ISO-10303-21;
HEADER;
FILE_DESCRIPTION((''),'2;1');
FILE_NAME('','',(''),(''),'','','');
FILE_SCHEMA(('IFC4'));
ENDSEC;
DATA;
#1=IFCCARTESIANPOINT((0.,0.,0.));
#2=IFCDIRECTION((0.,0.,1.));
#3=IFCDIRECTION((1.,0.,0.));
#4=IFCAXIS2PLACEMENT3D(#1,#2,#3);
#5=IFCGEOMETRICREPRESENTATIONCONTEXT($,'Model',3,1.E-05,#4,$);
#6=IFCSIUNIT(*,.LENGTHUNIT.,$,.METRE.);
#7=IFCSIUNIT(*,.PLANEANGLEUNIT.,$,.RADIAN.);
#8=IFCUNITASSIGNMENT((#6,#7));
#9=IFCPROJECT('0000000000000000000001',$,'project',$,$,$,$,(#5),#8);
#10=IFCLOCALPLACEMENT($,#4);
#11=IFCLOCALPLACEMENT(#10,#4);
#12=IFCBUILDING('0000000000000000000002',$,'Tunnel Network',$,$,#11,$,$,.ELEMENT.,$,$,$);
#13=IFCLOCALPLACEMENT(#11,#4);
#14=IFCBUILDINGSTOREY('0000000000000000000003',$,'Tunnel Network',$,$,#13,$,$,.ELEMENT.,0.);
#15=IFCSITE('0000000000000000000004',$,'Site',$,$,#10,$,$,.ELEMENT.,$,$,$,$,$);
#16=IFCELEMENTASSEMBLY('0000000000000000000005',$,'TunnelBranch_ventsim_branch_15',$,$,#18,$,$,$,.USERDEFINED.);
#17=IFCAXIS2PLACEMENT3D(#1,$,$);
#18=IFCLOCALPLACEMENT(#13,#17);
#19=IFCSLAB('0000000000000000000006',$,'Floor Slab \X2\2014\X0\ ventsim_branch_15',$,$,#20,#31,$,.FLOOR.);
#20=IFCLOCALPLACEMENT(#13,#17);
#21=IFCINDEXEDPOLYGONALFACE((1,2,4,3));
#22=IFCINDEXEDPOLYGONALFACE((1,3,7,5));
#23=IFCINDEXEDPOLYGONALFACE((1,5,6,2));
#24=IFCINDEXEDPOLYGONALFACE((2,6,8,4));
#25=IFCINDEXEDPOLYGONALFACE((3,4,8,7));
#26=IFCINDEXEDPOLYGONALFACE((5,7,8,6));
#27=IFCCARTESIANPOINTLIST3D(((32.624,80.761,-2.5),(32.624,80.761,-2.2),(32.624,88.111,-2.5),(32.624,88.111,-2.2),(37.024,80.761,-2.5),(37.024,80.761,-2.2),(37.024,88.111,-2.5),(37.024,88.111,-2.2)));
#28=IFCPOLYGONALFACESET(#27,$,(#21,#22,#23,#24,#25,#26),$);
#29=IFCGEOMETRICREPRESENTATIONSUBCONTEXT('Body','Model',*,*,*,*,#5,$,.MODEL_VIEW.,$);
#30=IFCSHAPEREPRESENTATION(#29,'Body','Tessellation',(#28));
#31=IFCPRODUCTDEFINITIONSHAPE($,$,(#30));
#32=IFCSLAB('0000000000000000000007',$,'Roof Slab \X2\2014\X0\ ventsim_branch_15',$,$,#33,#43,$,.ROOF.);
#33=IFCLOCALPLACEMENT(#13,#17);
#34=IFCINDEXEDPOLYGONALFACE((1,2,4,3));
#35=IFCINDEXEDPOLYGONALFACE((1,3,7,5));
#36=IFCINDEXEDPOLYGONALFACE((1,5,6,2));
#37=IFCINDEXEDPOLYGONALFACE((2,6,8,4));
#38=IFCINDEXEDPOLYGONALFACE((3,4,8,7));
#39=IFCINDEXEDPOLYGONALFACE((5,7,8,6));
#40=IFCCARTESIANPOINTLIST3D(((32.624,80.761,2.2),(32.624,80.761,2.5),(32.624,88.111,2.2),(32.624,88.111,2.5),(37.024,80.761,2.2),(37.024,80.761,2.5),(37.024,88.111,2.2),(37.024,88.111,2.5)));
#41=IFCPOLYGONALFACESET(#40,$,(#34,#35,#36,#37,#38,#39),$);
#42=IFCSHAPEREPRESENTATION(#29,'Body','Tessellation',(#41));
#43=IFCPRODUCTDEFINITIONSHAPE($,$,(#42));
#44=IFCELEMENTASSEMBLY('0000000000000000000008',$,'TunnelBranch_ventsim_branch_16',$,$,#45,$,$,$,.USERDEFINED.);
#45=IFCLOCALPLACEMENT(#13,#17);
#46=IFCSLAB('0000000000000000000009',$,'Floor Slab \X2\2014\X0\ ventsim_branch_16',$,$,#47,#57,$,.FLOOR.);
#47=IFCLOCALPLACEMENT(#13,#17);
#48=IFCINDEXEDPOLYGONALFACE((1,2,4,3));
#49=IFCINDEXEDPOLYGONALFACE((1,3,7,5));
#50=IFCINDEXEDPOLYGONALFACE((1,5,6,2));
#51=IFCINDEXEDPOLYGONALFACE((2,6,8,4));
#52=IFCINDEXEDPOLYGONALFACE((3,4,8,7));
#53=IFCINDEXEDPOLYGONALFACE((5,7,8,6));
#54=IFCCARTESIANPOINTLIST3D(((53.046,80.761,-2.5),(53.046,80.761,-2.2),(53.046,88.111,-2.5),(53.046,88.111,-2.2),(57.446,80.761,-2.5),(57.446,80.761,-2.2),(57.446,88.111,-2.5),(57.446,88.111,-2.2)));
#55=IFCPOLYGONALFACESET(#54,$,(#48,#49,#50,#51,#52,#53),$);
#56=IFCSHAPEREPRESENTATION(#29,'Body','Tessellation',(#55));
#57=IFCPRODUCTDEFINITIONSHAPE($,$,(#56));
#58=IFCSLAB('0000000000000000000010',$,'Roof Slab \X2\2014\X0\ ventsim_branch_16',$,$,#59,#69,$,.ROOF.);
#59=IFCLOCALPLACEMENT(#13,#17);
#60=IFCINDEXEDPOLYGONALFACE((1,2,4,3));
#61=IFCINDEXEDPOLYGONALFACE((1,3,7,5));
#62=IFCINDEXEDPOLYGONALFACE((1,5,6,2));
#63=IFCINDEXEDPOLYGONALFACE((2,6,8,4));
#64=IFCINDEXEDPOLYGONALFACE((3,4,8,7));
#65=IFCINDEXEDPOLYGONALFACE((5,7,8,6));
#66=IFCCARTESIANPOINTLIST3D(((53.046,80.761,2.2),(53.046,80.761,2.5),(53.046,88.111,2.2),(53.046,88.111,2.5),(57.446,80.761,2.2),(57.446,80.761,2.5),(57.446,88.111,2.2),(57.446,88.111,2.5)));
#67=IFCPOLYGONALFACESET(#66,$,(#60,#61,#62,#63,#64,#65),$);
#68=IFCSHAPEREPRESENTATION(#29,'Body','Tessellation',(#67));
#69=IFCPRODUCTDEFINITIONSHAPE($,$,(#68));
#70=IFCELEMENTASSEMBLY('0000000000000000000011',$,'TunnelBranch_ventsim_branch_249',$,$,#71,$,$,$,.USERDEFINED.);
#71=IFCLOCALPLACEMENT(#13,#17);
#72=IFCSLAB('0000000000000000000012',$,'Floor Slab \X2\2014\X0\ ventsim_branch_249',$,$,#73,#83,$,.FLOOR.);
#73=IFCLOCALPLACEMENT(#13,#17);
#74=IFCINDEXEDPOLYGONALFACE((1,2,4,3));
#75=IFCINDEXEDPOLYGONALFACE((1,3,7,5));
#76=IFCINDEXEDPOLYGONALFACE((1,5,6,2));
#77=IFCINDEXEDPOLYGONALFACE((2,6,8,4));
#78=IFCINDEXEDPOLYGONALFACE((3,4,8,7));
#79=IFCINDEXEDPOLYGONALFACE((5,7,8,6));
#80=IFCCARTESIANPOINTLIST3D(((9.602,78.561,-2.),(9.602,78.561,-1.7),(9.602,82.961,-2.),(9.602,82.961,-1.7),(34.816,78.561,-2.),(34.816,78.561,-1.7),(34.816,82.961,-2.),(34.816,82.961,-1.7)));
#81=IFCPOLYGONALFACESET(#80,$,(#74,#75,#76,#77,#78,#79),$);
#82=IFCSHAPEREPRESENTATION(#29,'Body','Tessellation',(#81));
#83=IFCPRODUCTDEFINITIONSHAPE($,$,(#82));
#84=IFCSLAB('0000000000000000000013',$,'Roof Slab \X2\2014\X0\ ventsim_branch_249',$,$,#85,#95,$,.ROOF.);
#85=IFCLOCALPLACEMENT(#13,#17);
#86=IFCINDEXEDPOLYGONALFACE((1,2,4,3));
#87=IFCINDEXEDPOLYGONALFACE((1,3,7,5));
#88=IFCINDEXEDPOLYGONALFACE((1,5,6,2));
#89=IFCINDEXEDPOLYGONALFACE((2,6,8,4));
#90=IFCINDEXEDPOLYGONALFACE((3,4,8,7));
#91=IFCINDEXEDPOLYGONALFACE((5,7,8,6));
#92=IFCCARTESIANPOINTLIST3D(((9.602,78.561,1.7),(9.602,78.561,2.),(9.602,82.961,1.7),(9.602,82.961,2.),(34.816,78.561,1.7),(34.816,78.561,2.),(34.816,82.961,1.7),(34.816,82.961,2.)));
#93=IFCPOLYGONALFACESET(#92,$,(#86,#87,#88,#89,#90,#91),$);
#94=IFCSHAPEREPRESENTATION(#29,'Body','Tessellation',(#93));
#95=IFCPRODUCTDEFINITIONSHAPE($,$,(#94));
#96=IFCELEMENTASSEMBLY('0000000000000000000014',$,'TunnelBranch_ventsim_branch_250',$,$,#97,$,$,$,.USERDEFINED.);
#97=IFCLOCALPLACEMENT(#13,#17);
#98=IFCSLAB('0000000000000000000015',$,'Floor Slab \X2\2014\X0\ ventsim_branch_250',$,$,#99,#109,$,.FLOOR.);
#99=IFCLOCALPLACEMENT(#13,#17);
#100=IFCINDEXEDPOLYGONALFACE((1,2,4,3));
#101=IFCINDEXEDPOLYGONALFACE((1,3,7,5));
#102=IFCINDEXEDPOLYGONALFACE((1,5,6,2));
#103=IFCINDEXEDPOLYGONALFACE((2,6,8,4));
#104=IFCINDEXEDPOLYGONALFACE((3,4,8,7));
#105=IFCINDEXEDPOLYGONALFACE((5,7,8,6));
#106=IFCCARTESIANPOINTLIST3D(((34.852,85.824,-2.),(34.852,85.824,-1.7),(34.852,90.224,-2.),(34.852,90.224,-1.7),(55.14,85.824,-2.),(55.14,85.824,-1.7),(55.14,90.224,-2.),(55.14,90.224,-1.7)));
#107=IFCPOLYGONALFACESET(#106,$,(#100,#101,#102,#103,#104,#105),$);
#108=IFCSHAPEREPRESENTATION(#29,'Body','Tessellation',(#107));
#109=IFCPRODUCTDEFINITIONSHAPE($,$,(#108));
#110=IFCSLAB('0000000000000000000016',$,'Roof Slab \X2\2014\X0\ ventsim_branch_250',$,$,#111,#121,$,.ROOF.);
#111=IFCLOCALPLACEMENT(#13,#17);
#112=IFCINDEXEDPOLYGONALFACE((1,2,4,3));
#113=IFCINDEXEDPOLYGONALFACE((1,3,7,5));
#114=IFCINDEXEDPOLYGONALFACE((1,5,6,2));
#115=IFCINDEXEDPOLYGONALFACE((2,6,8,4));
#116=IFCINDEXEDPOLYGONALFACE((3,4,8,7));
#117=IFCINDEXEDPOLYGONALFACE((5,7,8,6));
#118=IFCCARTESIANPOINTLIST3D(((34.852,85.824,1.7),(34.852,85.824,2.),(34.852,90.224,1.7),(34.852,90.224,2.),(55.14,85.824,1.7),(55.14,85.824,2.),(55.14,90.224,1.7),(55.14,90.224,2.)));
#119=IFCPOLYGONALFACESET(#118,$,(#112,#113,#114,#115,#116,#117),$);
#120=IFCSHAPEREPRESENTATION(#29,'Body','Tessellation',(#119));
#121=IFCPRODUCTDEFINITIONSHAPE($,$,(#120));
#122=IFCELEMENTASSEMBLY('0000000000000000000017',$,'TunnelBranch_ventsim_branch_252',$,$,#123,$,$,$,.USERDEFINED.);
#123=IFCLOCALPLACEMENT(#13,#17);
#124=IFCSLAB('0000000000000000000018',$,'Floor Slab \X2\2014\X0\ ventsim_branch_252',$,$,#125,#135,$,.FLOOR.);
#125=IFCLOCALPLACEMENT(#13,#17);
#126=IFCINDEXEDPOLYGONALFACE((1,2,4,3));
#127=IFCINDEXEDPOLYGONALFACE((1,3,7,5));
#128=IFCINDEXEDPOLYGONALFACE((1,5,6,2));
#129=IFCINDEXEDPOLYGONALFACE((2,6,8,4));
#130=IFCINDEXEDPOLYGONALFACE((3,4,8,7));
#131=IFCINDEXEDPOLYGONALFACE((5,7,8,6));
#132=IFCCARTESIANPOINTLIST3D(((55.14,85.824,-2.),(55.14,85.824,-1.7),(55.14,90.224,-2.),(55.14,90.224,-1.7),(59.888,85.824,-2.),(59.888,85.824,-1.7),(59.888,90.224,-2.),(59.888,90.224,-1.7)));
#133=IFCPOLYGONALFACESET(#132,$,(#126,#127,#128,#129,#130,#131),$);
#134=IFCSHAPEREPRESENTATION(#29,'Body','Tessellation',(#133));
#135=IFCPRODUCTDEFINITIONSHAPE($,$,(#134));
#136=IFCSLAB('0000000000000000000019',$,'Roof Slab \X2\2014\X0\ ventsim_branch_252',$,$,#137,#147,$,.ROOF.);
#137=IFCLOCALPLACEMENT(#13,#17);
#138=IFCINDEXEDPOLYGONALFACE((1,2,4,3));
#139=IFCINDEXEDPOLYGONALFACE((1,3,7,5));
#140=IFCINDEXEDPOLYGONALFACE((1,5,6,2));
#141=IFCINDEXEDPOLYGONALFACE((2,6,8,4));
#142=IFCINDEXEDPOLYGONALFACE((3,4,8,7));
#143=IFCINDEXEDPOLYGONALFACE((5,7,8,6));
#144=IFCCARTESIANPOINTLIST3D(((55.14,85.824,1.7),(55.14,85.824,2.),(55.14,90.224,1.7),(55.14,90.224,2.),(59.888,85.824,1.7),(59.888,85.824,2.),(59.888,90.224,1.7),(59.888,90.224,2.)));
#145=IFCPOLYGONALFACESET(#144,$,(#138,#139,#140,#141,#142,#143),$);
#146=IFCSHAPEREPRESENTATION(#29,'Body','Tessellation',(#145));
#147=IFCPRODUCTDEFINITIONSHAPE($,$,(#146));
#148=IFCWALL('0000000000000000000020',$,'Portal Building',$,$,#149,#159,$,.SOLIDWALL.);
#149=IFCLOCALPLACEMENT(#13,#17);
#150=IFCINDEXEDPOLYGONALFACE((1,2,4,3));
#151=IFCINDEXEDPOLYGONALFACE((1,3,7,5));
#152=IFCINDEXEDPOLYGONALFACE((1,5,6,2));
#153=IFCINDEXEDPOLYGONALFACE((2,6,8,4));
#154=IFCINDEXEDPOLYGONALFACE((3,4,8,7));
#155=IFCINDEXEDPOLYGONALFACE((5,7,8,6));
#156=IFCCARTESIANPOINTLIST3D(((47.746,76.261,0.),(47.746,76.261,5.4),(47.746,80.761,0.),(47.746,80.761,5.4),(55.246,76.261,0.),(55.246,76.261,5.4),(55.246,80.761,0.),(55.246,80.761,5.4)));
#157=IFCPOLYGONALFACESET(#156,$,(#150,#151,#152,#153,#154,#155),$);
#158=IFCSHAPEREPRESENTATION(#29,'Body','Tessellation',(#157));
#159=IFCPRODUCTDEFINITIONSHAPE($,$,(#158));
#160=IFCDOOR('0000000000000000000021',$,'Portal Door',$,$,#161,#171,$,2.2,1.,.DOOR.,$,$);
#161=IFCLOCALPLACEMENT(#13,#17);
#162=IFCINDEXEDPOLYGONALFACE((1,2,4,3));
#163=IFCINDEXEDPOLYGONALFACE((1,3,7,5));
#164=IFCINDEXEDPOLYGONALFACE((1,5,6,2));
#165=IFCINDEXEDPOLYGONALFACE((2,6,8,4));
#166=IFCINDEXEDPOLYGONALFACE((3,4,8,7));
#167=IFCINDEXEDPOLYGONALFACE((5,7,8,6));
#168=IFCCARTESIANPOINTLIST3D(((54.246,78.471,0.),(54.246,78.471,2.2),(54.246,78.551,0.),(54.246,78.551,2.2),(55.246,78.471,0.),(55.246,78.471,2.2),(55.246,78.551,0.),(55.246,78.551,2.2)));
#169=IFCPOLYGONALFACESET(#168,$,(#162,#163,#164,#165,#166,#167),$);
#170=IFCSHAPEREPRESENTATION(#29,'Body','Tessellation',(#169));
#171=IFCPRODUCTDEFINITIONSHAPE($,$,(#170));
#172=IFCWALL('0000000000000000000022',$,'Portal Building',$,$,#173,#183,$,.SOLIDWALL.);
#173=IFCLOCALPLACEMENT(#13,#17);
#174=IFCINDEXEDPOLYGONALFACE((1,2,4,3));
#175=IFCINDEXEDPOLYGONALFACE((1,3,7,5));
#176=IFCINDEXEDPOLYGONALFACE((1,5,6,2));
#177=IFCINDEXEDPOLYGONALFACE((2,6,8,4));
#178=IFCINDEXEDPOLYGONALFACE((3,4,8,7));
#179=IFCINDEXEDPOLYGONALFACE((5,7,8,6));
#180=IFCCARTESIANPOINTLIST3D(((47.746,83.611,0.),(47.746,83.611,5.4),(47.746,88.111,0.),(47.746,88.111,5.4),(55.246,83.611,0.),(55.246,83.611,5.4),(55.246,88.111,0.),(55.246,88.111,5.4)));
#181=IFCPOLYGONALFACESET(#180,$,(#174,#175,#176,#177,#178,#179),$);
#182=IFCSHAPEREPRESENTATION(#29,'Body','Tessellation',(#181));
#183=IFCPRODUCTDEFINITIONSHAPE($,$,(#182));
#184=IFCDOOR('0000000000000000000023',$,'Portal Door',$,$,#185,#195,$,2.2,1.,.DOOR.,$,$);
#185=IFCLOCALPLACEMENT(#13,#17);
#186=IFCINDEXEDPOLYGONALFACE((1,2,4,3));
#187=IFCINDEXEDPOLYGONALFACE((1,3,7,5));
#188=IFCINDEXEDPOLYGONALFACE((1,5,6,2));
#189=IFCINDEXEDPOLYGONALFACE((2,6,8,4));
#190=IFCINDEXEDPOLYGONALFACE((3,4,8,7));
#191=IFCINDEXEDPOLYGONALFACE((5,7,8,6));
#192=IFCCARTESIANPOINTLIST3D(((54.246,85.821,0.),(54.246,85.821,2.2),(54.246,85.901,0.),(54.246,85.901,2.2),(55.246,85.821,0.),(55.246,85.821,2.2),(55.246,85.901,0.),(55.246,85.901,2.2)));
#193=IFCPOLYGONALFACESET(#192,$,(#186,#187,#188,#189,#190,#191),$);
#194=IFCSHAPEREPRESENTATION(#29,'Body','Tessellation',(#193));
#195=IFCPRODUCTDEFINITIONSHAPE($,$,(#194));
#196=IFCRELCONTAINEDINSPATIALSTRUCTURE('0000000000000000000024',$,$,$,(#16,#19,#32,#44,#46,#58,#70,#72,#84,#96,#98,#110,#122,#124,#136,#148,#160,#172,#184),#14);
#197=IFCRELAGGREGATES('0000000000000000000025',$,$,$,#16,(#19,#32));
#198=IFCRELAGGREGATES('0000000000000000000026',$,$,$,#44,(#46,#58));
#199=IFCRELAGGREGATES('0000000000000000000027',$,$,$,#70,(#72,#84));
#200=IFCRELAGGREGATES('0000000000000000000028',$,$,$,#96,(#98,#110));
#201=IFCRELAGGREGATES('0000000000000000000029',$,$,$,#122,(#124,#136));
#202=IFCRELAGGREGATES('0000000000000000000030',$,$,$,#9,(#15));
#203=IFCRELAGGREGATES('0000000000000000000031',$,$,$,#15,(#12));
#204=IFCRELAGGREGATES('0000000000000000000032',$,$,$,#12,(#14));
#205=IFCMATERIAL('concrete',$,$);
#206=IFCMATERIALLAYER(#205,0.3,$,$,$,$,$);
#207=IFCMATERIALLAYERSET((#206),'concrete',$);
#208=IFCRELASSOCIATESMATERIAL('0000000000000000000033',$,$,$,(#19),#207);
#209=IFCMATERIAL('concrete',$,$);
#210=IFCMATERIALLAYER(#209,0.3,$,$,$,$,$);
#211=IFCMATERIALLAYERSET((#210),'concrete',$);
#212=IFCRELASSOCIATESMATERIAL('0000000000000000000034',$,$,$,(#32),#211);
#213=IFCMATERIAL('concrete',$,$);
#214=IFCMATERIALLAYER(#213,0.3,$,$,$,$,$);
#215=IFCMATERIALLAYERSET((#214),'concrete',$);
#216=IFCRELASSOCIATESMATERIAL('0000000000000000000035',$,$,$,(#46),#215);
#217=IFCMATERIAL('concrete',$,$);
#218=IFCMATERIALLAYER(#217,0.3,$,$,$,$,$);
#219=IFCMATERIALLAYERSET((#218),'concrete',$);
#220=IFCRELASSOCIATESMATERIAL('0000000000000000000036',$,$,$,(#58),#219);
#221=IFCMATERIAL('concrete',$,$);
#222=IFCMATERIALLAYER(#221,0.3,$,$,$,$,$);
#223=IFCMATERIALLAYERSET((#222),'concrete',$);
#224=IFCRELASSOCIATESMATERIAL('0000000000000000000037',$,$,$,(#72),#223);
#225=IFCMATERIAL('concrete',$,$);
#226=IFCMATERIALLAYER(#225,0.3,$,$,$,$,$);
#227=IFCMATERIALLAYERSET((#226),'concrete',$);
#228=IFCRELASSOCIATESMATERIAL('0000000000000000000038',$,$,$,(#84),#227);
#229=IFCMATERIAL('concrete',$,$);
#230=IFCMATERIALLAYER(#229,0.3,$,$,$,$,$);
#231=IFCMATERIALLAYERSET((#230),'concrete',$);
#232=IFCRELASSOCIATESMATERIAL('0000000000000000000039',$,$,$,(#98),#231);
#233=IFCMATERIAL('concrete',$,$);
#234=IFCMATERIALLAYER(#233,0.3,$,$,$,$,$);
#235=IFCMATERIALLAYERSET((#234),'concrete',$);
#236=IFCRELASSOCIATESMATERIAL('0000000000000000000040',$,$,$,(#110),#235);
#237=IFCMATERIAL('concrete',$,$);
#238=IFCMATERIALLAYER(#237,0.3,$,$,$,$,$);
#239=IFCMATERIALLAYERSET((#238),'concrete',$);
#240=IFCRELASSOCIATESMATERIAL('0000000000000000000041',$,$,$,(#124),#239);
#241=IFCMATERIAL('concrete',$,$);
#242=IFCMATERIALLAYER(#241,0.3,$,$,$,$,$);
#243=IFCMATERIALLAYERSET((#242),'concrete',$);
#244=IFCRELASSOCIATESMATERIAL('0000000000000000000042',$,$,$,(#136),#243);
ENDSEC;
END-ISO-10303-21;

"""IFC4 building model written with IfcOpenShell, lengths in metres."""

from ifc_helpers import new_model, si_unit, frame, origin_with_axes, origin_2d_with_axis, place, context, subcontext, project, spatial, rectangle, extrude, material, layer, layer_set, layer_usage, element, aggregate, save


model = new_model("IFC4")

# Units and contexts
model_context = context("Model", 3, precision=1e-05, world=origin_with_axes())
body_context = subcontext(model_context, "Body", "Model", "MODEL_VIEW")
ifc_project = project(units=[si_unit("LENGTHUNIT", "METRE"), si_unit("PLANEANGLEUNIT", "RADIAN")], contexts=[model_context])

# Site, building, storey
site_placement = place(None, origin_with_axes())
site = spatial("IfcSite", under=ifc_project, at=site_placement, Name="Site", CompositionType="ELEMENT")
building_placement = place(site_placement, origin_with_axes())
building = spatial("IfcBuilding", under=site, at=building_placement, Name="Tunnel Network", CompositionType="ELEMENT")
storey_placement = place(building_placement, origin_with_axes())
storey = spatial("IfcBuildingStorey", under=building, at=storey_placement, Name="Tunnel Network", CompositionType="ELEMENT", Elevation=0.0)

# Element assemblies, slabs
assembly_1_placement = place(storey_placement, frame((32.474, 80.761, 0.0), z_axis=(0.0, 1.0, 0.0), x_axis=(1.0, 0.0, 0.0)))
assembly_1 = element("IfcElementAssembly", 1, at=assembly_1_placement, inside=storey, Name="TunnelBranch_ventsim_branch_15", PredefinedType="USERDEFINED")
ifc_material_1 = material(Name="concrete")
ifc_layer_1 = layer(ifc_material_1, 0.3)
ifc_layer_set_1 = layer_set([ifc_layer_1], Name="concrete")
ifc_layer_usage_1 = layer_usage(ifc_layer_set_1, "AXIS3", "POSITIVE", 0.0)
slab_1_placement = place(storey_placement, frame((34.824, 80.761, -2.35), z_axis=(0.0, 1.0, 0.0), x_axis=(1.0, 0.0, 0.0)))
slab_1 = element("IfcSlab", 2, at=slab_1_placement, inside=storey, material=ifc_layer_usage_1, Name="Floor Slab — ventsim_branch_15", PredefinedType="FLOOR", context=body_context, shape_type="SweptSolid", body=[
    extrude(rectangle(XDim=4.4, YDim=0.3, at=origin_2d_with_axis()), origin_with_axes(), (0.0, 0.0, 1.0), 7.35),
])
ifc_material_2 = material(Name="concrete")
ifc_layer_2 = layer(ifc_material_2, 0.3)
ifc_layer_set_2 = layer_set([ifc_layer_2], Name="concrete")
ifc_layer_usage_2 = layer_usage(ifc_layer_set_2, "AXIS3", "POSITIVE", 0.0)
slab_2_placement = place(storey_placement, frame((34.824, 80.761, 2.35), z_axis=(0.0, 1.0, 0.0), x_axis=(1.0, 0.0, 0.0)))
slab_2 = element("IfcSlab", 3, at=slab_2_placement, inside=storey, material=ifc_layer_usage_2, Name="Roof Slab — ventsim_branch_15", PredefinedType="ROOF", context=body_context, shape_type="SweptSolid", body=[
    extrude(rectangle(XDim=4.4, YDim=0.3, at=origin_2d_with_axis()), origin_with_axes(), (0.0, 0.0, 1.0), 7.35),
])
assembly_2_placement = place(storey_placement, frame((52.896, 80.761, 0.0), z_axis=(0.0, 1.0, 0.0), x_axis=(1.0, 0.0, 0.0)))
assembly_2 = element("IfcElementAssembly", 4, at=assembly_2_placement, inside=storey, Name="TunnelBranch_ventsim_branch_16", PredefinedType="USERDEFINED")
ifc_material_3 = material(Name="concrete")
ifc_layer_3 = layer(ifc_material_3, 0.3)
ifc_layer_set_3 = layer_set([ifc_layer_3], Name="concrete")
ifc_layer_usage_3 = layer_usage(ifc_layer_set_3, "AXIS3", "POSITIVE", 0.0)
slab_3_placement = place(storey_placement, frame((55.246, 80.761, -2.35), z_axis=(0.0, 1.0, 0.0), x_axis=(1.0, 0.0, 0.0)))
slab_3 = element("IfcSlab", 5, at=slab_3_placement, inside=storey, material=ifc_layer_usage_3, Name="Floor Slab — ventsim_branch_16", PredefinedType="FLOOR", context=body_context, shape_type="SweptSolid", body=[
    extrude(rectangle(XDim=4.4, YDim=0.3, at=origin_2d_with_axis()), origin_with_axes(), (0.0, 0.0, 1.0), 7.35),
])
ifc_material_4 = material(Name="concrete")
ifc_layer_4 = layer(ifc_material_4, 0.3)
ifc_layer_set_4 = layer_set([ifc_layer_4], Name="concrete")
ifc_layer_usage_4 = layer_usage(ifc_layer_set_4, "AXIS3", "POSITIVE", 0.0)
slab_4_placement = place(storey_placement, frame((55.246, 80.761, 2.35), z_axis=(0.0, 1.0, 0.0), x_axis=(1.0, 0.0, 0.0)))
slab_4 = element("IfcSlab", 6, at=slab_4_placement, inside=storey, material=ifc_layer_usage_4, Name="Roof Slab — ventsim_branch_16", PredefinedType="ROOF", context=body_context, shape_type="SweptSolid", body=[
    extrude(rectangle(XDim=4.4, YDim=0.3, at=origin_2d_with_axis()), origin_with_axes(), (0.0, 0.0, 1.0), 7.35),
])
assembly_3_placement = place(storey_placement, frame((34.816, 78.411, 0.0), z_axis=(-1.0, 0.0, 0.0), x_axis=(0.0, 1.0, 0.0)))
assembly_3 = element("IfcElementAssembly", 7, at=assembly_3_placement, inside=storey, Name="TunnelBranch_ventsim_branch_249", PredefinedType="USERDEFINED")
ifc_material_5 = material(Name="concrete")
ifc_layer_5 = layer(ifc_material_5, 0.3)
ifc_layer_set_5 = layer_set([ifc_layer_5], Name="concrete")
ifc_layer_usage_5 = layer_usage(ifc_layer_set_5, "AXIS3", "POSITIVE", 0.0)
slab_5_placement = place(storey_placement, frame((34.816, 80.761, -1.85), z_axis=(-1.0, 0.0, 0.0), x_axis=(0.0, 1.0, 0.0)))
slab_5 = element("IfcSlab", 8, at=slab_5_placement, inside=storey, material=ifc_layer_usage_5, Name="Floor Slab — ventsim_branch_249", PredefinedType="FLOOR", context=body_context, shape_type="SweptSolid", body=[
    extrude(rectangle(XDim=4.4, YDim=0.3, at=origin_2d_with_axis()), origin_with_axes(), (0.0, 0.0, 1.0), 25.214),
])
ifc_material_6 = material(Name="concrete")
ifc_layer_6 = layer(ifc_material_6, 0.3)
ifc_layer_set_6 = layer_set([ifc_layer_6], Name="concrete")
ifc_layer_usage_6 = layer_usage(ifc_layer_set_6, "AXIS3", "POSITIVE", 0.0)
slab_6_placement = place(storey_placement, frame((34.816, 80.761, 1.85), z_axis=(-1.0, 0.0, 0.0), x_axis=(0.0, 1.0, 0.0)))
slab_6 = element("IfcSlab", 9, at=slab_6_placement, inside=storey, material=ifc_layer_usage_6, Name="Roof Slab — ventsim_branch_249", PredefinedType="ROOF", context=body_context, shape_type="SweptSolid", body=[
    extrude(rectangle(XDim=4.4, YDim=0.3, at=origin_2d_with_axis()), origin_with_axes(), (0.0, 0.0, 1.0), 25.214),
])
assembly_4_placement = place(storey_placement, frame((55.14, 85.674, 0.0), z_axis=(-1.0, 0.0, 0.0), x_axis=(0.0, 1.0, 0.0)))
assembly_4 = element("IfcElementAssembly", 10, at=assembly_4_placement, inside=storey, Name="TunnelBranch_ventsim_branch_250", PredefinedType="USERDEFINED")
ifc_material_7 = material(Name="concrete")
ifc_layer_7 = layer(ifc_material_7, 0.3)
ifc_layer_set_7 = layer_set([ifc_layer_7], Name="concrete")
ifc_layer_usage_7 = layer_usage(ifc_layer_set_7, "AXIS3", "POSITIVE", 0.0)
slab_7_placement = place(storey_placement, frame((55.14, 88.024, -1.85), z_axis=(-1.0, 0.0, 0.0), x_axis=(0.0, 1.0, 0.0)))
slab_7 = element("IfcSlab", 11, at=slab_7_placement, inside=storey, material=ifc_layer_usage_7, Name="Floor Slab — ventsim_branch_250", PredefinedType="FLOOR", context=body_context, shape_type="SweptSolid", body=[
    extrude(rectangle(XDim=4.4, YDim=0.3, at=origin_2d_with_axis()), origin_with_axes(), (0.0, 0.0, 1.0), 20.288),
])
ifc_material_8 = material(Name="concrete")
ifc_layer_8 = layer(ifc_material_8, 0.3)
ifc_layer_set_8 = layer_set([ifc_layer_8], Name="concrete")
ifc_layer_usage_8 = layer_usage(ifc_layer_set_8, "AXIS3", "POSITIVE", 0.0)
slab_8_placement = place(storey_placement, frame((55.14, 88.024, 1.85), z_axis=(-1.0, 0.0, 0.0), x_axis=(0.0, 1.0, 0.0)))
slab_8 = element("IfcSlab", 12, at=slab_8_placement, inside=storey, material=ifc_layer_usage_8, Name="Roof Slab — ventsim_branch_250", PredefinedType="ROOF", context=body_context, shape_type="SweptSolid", body=[
    extrude(rectangle(XDim=4.4, YDim=0.3, at=origin_2d_with_axis()), origin_with_axes(), (0.0, 0.0, 1.0), 20.288),
])
assembly_5_placement = place(storey_placement, frame((55.14, 90.374, 0.0), z_axis=(1.0, 0.0, 0.0), x_axis=(0.0, -1.0, 0.0)))
assembly_5 = element("IfcElementAssembly", 13, at=assembly_5_placement, inside=storey, Name="TunnelBranch_ventsim_branch_252", PredefinedType="USERDEFINED")
ifc_material_9 = material(Name="concrete")
ifc_layer_9 = layer(ifc_material_9, 0.3)
ifc_layer_set_9 = layer_set([ifc_layer_9], Name="concrete")
ifc_layer_usage_9 = layer_usage(ifc_layer_set_9, "AXIS3", "POSITIVE", 0.0)
slab_9_placement = place(storey_placement, frame((55.14, 88.024, -1.85), z_axis=(1.0, 0.0, 0.0), x_axis=(0.0, -1.0, 0.0)))
slab_9 = element("IfcSlab", 14, at=slab_9_placement, inside=storey, material=ifc_layer_usage_9, Name="Floor Slab — ventsim_branch_252", PredefinedType="FLOOR", context=body_context, shape_type="SweptSolid", body=[
    extrude(rectangle(XDim=4.4, YDim=0.3, at=origin_2d_with_axis()), origin_with_axes(), (0.0, 0.0, 1.0), 4.748),
])
ifc_material_10 = material(Name="concrete")
ifc_layer_10 = layer(ifc_material_10, 0.3)
ifc_layer_set_10 = layer_set([ifc_layer_10], Name="concrete")
ifc_layer_usage_10 = layer_usage(ifc_layer_set_10, "AXIS3", "POSITIVE", 0.0)
slab_10_placement = place(storey_placement, frame((55.14, 88.024, 1.85), z_axis=(1.0, 0.0, 0.0), x_axis=(0.0, -1.0, 0.0)))
slab_10 = element("IfcSlab", 15, at=slab_10_placement, inside=storey, material=ifc_layer_usage_10, Name="Roof Slab — ventsim_branch_252", PredefinedType="ROOF", context=body_context, shape_type="SweptSolid", body=[
    extrude(rectangle(XDim=4.4, YDim=0.3, at=origin_2d_with_axis()), origin_with_axes(), (0.0, 0.0, 1.0), 4.748),
])

# Wall
wall_1_placement = place(storey_placement, frame((51.496, 78.511, 0.0), z_axis=(0.0, 0.0, 1.0), x_axis=(1.0, 0.0, 0.0)))
element("IfcWall", 16, at=wall_1_placement, inside=storey, Name="Portal Building", PredefinedType="SOLIDWALL", context=body_context, shape_type="SweptSolid", body=[
    extrude(rectangle(XDim=7.5, YDim=4.5, at=origin_2d_with_axis()), origin_with_axes(), (0.0, 0.0, 1.0), 5.4),
])

# Door
door_1_placement = place(storey_placement, frame((54.746, 78.511, 0.0), z_axis=(0.0, 0.0, 1.0), x_axis=(1.0, 0.0, 0.0)))
element("IfcDoor", 17, at=door_1_placement, inside=storey, Name="Portal Door", OverallHeight=2.2, OverallWidth=1.0, PredefinedType="DOOR", context=body_context, shape_type="SweptSolid", body=[
    extrude(rectangle(XDim=1.0, YDim=0.08, at=origin_2d_with_axis()), origin_with_axes(), (0.0, 0.0, 1.0), 2.2),
])

# Wall
wall_2_placement = place(storey_placement, frame((51.496, 85.861, 0.0), z_axis=(0.0, 0.0, 1.0), x_axis=(1.0, 0.0, 0.0)))
element("IfcWall", 18, at=wall_2_placement, inside=storey, Name="Portal Building", PredefinedType="SOLIDWALL", context=body_context, shape_type="SweptSolid", body=[
    extrude(rectangle(XDim=7.5, YDim=4.5, at=origin_2d_with_axis()), origin_with_axes(), (0.0, 0.0, 1.0), 5.4),
])

# Door
door_2_placement = place(storey_placement, frame((54.746, 85.861, 0.0), z_axis=(0.0, 0.0, 1.0), x_axis=(1.0, 0.0, 0.0)))
element("IfcDoor", 19, at=door_2_placement, inside=storey, Name="Portal Door", OverallHeight=2.2, OverallWidth=1.0, PredefinedType="DOOR", context=body_context, shape_type="SweptSolid", body=[
    extrude(rectangle(XDim=1.0, YDim=0.08, at=origin_2d_with_axis()), origin_with_axes(), (0.0, 0.0, 1.0), 2.2),
])

aggregate(assembly_1, [slab_1, slab_2])
aggregate(assembly_2, [slab_3, slab_4])
aggregate(assembly_3, [slab_5, slab_6])
aggregate(assembly_4, [slab_7, slab_8])

aggregate(assembly_5, [slab_9, slab_10])

save(model, "model.ifc")
